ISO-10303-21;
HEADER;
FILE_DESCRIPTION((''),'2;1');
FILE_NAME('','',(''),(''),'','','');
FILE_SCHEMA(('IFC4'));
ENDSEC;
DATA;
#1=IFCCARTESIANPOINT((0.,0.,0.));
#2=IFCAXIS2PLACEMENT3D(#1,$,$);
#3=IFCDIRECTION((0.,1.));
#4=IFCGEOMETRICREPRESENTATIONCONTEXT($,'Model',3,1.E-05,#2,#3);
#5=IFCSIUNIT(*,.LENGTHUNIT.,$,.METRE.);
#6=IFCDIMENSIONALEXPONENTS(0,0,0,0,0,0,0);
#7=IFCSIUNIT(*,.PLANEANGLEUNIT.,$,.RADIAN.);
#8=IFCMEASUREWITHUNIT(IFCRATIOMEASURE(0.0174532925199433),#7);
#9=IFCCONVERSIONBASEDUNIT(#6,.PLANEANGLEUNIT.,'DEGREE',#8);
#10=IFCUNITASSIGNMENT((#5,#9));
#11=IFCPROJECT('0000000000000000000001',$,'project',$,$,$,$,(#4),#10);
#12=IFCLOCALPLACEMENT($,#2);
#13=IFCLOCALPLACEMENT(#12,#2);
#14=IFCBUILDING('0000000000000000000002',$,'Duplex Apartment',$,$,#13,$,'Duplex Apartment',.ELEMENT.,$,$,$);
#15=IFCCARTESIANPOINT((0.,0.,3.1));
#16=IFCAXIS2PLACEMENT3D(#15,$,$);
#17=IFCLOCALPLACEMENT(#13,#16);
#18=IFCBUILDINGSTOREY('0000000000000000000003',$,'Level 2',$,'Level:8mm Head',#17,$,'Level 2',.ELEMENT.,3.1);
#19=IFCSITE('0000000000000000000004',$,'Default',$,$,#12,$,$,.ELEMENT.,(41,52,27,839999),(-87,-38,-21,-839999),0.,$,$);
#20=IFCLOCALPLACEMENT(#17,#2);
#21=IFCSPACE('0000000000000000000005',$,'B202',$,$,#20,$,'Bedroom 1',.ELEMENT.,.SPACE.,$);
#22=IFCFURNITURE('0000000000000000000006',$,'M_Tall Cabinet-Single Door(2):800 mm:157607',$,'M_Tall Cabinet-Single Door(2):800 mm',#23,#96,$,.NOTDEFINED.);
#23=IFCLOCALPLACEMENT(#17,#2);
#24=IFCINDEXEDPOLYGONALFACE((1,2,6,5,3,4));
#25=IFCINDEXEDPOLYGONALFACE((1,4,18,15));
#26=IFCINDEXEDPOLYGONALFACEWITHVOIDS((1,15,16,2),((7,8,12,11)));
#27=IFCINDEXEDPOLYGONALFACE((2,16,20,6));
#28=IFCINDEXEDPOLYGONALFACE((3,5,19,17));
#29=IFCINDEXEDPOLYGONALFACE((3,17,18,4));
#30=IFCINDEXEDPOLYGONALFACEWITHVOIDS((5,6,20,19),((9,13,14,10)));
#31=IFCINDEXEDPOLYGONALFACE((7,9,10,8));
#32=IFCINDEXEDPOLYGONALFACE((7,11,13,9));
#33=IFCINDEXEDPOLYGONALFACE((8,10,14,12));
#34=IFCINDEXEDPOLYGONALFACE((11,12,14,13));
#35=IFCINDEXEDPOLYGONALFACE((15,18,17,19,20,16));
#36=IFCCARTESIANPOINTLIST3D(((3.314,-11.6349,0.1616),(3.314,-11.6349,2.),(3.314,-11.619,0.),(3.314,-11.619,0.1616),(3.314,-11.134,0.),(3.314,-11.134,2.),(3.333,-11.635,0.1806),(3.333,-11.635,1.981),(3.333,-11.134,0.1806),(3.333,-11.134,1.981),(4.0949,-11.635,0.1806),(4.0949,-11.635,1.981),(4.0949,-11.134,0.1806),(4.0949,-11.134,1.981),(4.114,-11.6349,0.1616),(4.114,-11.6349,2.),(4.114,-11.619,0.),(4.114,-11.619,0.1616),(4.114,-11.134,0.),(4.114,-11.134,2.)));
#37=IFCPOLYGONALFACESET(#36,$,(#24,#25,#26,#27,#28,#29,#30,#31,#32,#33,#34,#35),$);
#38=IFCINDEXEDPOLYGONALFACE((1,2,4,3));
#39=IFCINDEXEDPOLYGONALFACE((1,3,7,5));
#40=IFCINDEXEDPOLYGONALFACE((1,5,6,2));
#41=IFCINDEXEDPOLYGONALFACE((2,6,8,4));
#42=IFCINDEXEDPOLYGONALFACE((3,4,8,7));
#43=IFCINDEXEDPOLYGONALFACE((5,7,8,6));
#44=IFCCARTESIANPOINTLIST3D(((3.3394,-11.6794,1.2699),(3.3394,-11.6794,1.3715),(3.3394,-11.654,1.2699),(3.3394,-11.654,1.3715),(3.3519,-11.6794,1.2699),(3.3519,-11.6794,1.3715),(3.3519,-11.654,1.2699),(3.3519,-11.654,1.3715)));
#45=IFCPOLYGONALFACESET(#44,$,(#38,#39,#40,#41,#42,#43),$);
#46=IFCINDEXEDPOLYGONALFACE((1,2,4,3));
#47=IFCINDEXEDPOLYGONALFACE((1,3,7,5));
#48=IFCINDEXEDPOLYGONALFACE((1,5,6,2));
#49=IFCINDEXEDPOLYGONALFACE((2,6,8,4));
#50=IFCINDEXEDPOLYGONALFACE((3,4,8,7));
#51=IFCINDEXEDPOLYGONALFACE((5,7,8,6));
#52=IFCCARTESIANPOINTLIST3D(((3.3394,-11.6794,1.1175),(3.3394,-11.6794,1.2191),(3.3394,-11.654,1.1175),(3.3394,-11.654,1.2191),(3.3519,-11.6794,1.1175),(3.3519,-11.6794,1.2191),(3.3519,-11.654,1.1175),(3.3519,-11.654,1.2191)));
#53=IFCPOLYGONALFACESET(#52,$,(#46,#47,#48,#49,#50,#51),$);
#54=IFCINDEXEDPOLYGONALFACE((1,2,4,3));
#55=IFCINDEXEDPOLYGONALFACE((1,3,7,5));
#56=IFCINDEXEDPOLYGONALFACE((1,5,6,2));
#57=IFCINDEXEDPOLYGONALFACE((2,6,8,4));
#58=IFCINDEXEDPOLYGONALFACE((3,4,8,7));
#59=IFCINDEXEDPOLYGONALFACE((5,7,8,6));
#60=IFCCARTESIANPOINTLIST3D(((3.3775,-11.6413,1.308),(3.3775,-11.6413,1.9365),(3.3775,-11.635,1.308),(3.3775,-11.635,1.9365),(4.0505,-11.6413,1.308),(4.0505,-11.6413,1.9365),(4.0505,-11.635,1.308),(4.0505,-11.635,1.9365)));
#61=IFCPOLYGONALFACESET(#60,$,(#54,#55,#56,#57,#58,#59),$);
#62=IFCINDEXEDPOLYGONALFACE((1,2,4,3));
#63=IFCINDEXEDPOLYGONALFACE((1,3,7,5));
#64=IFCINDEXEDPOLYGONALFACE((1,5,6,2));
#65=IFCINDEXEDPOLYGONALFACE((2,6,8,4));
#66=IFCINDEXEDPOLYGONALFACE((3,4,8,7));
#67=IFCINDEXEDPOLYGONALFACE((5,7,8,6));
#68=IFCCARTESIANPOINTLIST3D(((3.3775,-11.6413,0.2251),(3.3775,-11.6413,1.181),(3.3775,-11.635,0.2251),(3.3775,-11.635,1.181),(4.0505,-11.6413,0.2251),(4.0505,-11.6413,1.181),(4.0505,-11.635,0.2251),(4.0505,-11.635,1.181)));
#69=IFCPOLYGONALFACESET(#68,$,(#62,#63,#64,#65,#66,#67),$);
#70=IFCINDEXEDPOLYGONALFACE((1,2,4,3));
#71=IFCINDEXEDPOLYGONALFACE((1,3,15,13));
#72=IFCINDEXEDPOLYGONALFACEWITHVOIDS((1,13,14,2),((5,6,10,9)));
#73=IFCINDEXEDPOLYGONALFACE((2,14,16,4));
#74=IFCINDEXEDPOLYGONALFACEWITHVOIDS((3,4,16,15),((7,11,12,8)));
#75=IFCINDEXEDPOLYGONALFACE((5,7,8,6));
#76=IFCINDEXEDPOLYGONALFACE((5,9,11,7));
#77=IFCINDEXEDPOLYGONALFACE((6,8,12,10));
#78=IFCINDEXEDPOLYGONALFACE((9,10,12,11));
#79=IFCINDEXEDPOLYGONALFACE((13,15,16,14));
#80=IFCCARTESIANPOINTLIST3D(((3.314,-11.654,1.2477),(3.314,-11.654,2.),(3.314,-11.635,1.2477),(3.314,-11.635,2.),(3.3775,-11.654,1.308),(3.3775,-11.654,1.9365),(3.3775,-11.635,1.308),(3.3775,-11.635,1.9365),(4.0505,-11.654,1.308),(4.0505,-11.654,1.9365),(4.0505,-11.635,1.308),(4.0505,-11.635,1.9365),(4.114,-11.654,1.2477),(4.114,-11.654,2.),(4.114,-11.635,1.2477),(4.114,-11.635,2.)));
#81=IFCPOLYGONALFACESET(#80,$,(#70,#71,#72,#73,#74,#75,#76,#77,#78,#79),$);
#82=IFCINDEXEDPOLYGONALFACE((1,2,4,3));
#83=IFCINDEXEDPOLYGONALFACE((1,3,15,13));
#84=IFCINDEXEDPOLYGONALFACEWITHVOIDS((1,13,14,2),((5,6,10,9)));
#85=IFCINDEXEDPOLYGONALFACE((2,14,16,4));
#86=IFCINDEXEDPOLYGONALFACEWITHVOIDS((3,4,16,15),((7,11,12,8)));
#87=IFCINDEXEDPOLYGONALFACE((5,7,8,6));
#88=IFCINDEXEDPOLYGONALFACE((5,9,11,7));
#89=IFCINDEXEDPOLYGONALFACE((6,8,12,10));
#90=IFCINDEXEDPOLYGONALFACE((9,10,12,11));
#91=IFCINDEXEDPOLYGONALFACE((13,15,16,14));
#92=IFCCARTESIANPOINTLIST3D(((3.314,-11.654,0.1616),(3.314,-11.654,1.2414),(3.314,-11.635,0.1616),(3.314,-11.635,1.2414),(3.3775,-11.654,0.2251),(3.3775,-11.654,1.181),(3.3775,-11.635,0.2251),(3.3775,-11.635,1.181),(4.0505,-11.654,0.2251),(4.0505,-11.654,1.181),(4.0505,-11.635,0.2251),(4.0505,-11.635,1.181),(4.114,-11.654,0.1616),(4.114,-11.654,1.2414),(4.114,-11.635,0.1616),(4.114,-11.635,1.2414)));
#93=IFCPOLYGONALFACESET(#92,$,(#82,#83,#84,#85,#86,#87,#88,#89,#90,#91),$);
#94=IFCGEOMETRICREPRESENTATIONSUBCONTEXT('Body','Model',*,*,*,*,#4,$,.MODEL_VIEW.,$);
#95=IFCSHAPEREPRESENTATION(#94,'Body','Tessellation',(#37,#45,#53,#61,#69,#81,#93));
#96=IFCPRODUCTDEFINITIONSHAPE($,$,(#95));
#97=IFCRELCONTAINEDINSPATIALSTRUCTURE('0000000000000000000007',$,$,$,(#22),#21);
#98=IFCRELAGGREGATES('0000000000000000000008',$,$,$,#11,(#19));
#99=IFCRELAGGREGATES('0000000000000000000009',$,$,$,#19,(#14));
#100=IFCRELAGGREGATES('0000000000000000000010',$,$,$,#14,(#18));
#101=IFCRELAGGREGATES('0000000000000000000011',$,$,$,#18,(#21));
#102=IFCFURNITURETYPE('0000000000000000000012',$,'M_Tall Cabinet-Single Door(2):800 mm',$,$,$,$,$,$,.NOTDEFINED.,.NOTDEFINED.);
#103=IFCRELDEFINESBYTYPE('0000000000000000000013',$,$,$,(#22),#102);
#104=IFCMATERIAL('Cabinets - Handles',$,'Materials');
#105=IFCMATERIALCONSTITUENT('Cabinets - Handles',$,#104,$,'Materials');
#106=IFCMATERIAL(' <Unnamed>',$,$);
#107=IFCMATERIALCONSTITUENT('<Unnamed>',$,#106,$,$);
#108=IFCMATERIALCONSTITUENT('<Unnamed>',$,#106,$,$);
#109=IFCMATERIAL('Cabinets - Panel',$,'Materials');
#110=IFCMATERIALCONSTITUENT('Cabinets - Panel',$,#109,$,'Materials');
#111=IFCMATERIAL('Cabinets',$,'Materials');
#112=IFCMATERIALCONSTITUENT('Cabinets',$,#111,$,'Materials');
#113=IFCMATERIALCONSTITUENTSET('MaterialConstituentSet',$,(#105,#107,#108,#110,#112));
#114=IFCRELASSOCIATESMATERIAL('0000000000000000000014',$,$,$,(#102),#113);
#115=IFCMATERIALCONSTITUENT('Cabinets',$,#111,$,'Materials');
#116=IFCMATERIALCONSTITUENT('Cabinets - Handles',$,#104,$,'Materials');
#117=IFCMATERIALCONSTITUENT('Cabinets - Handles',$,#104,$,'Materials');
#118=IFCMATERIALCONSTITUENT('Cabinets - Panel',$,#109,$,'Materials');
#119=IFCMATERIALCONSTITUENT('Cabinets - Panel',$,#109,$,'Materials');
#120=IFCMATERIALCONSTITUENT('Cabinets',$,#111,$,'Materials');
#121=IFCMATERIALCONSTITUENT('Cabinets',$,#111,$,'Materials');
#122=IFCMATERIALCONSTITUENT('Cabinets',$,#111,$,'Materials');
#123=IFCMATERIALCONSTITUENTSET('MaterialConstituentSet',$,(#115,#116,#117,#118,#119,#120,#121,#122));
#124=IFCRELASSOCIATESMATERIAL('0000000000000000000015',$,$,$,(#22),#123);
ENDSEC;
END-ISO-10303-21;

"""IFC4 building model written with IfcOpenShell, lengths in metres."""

from ifc_helpers import new_model, entity, si_unit, converted_unit, direction, frame, origin, place, context, subcontext, project, spatial, indexed_curve, outline, extrude, source, transform, mapped, material, constituent, constituent_set, type_object, type_shapes, element, save


model = new_model("IFC4")

# Units and contexts
model_context = context("Model", 3, precision=1e-05, world=origin(), true_north=direction((0.0, 1.0)))
body_context = subcontext(model_context, "Body", "Model", "MODEL_VIEW")
ifc_project = project(units=[si_unit("LENGTHUNIT", "METRE"), converted_unit("PLANEANGLEUNIT", "DEGREE", entity("IfcRatioMeasure", 0.0174532925199433), si_unit("PLANEANGLEUNIT", "RADIAN"), dimensions=[0, 0, 0, 0, 0, 0, 0])], contexts=[model_context])

# Site, building, storey
site_placement = place(None, origin())
site = spatial("IfcSite", under=ifc_project, at=site_placement, Name="Default", CompositionType="ELEMENT", RefLatitude=(41, 52, 27, 839999), RefLongitude=(-87, -38, -21, -839999), RefElevation=0.0)
building_placement = place(site_placement, origin())
building = spatial("IfcBuilding", under=site, at=building_placement, Name="Duplex Apartment", LongName="Duplex Apartment", CompositionType="ELEMENT")
storey_placement = place(building_placement, frame((0.0, 0.0, 3.1)))
storey = spatial("IfcBuildingStorey", under=building, at=storey_placement, Name="Level 2", ObjectType="Level:8mm Head", LongName="Level 2", CompositionType="ELEMENT", Elevation=3.1)

# Shared definitions
space_1_placement = place(storey_placement, origin())
space_1 = spatial("IfcSpace", under=storey, at=space_1_placement, Name="B202", LongName="Bedroom 1", CompositionType="ELEMENT", PredefinedType="SPACE")

# Furniture, opening
ifc_material_1 = material(Name="Cabinets", Category="Materials")
ifc_material_2 = material(Name="Cabinets - Handles", Category="Materials")
ifc_material_3 = material(Name="Cabinets - Panel", Category="Materials")
ifc_material_4 = material(Name=" <Unnamed>")
ifc_constituent_1 = constituent(ifc_material_1, Name="Cabinets", Category="Materials")
ifc_constituent_2 = constituent(ifc_material_2, Name="Cabinets - Handles", Category="Materials")
ifc_constituent_3 = constituent(ifc_material_2, Name="Cabinets - Handles", Category="Materials")
ifc_constituent_4 = constituent(ifc_material_3, Name="Cabinets - Panel", Category="Materials")
ifc_constituent_5 = constituent(ifc_material_3, Name="Cabinets - Panel", Category="Materials")
ifc_constituent_6 = constituent(ifc_material_1, Name="Cabinets", Category="Materials")
ifc_constituent_7 = constituent(ifc_material_1, Name="Cabinets", Category="Materials")
ifc_constituent_8 = constituent(ifc_material_1, Name="Cabinets", Category="Materials")
ifc_constituent_set_1 = constituent_set(constituents=[ifc_constituent_1, ifc_constituent_2, ifc_constituent_3, ifc_constituent_4, ifc_constituent_5, ifc_constituent_6, ifc_constituent_7, ifc_constituent_8], Name="MaterialConstituentSet")
ifc_constituent_9 = constituent(ifc_material_2, Name="Cabinets - Handles", Category="Materials")
ifc_constituent_10 = constituent(ifc_material_4, Name="<Unnamed>")
ifc_constituent_11 = constituent(ifc_material_4, Name="<Unnamed>")
ifc_constituent_12 = constituent(ifc_material_3, Name="Cabinets - Panel", Category="Materials")
ifc_constituent_13 = constituent(ifc_material_1, Name="Cabinets", Category="Materials")
ifc_constituent_set_2 = constituent_set(constituents=[ifc_constituent_9, ifc_constituent_10, ifc_constituent_11, ifc_constituent_12, ifc_constituent_13], Name="MaterialConstituentSet")
furniture_type_1 = type_object("IfcFurnitureType", Name="M_Tall Cabinet-Single Door(2):800 mm", AssemblyPlace="NOTDEFINED", PredefinedType="NOTDEFINED", material=ifc_constituent_set_2)
shared_shape_1 = source(origin(), body_context, "Body", "SweptSolid", [
    extrude(outline(indexed_curve([(-0.5589, -0.1723), (1.2795, -0.1723), (1.2795, 0.3286), (-0.7205, 0.3286), (-0.7205, -0.1563), (-0.5589, -0.1563), (-0.5589, -0.1723)], self_intersect=False)), frame((-0.3813, 0.3286, 0.7205), z_axis=(1.0, 0.0, 0.0), x_axis=(0.0, 0.0, 1.0)), (0.0, 0.0, 1.0), 0.8),
    extrude(outline(indexed_curve([(-0.0063, -0.0127), (0.0063, -0.0127), (0.0063, 0.0127), (-0.0063, 0.0127), (-0.0063, -0.0127)], self_intersect=False)), frame((0.3871, 0.5327, 1.2699), z_axis=(0.0, 0.0, 1.0), x_axis=(-1.0, 0.0, 0.0)), (0.0, 0.0, 1.0), 0.1016),
    extrude(outline(indexed_curve([(-0.0063, -0.0127), (0.0063, -0.0127), (0.0063, 0.0127), (-0.0063, 0.0127), (-0.0063, -0.0127)], self_intersect=False)), frame((0.3871, 0.5327, 1.1175), z_axis=(0.0, 0.0, 1.0), x_axis=(-1.0, 0.0, 0.0)), (0.0, 0.0, 1.0), 0.1016),
    extrude(outline(indexed_curve([(-0.3365, -0.0032), (0.3365, -0.0032), (0.3365, 0.0032), (-0.3365, 0.0032), (-0.3365, -0.0032)], self_intersect=False)), frame((0.0187, 0.5041, 1.308), z_axis=(0.0, 0.0, 1.0), x_axis=(-1.0, 0.0, 0.0)), (0.0, 0.0, 1.0), 0.6285),
    extrude(outline(indexed_curve([(-0.3365, -0.0032), (0.3365, -0.0032), (0.3365, 0.0032), (-0.3365, 0.0032), (-0.3365, -0.0032)], self_intersect=False)), frame((0.0187, 0.5041, 0.2251), z_axis=(0.0, 0.0, 1.0), x_axis=(-1.0, 0.0, 0.0)), (0.0, 0.0, 1.0), 0.956),
    extrude(outline(indexed_curve([(-0.3761, -0.4), (0.3761, -0.4), (0.3761, 0.4), (-0.3761, 0.4), (-0.3761, -0.4)], self_intersect=False), holes=[indexed_curve([(-0.3126, -0.3365), (-0.3126, 0.3365), (0.3158, 0.3365), (0.3158, -0.3365), (-0.3126, -0.3365)], self_intersect=False)]), frame((0.0187, 0.501, 1.6239), z_axis=(0.0, 1.0, 0.0), x_axis=(0.0, 0.0, -1.0)), (0.0, 0.0, 1.0), 0.0191),
    extrude(outline(indexed_curve([(-0.4, -0.5399), (0.4, -0.5399), (0.4, 0.5399), (-0.4, 0.5399), (-0.4, -0.5399)], self_intersect=False), holes=[indexed_curve([(-0.3365, 0.4796), (0.3365, 0.4796), (0.3365, -0.4764), (-0.3365, -0.4764), (-0.3365, 0.4796)], self_intersect=False)]), frame((0.0187, 0.501, 0.7015), z_axis=(0.0, 1.0, 0.0), x_axis=(-1.0, 0.0, 0.0)), (0.0, 0.0, 1.0), 0.0191),
    extrude(outline(indexed_curve([(-0.381, -0.0095), (0.381, -0.0095), (0.381, 0.0095), (-0.381, 0.0095), (-0.381, -0.0095)], self_intersect=False)), frame((0.0187, 0.0095, 0.1806), z_axis=(0.0, 0.0, 1.0), x_axis=(-1.0, 0.0, 0.0)), (0.0, 0.0, 1.0), 1.8003),
])
type_shapes(furniture_type_1, [shared_shape_1])
furniture_1_placement = place(space_1_placement, frame((3.7327, -11.134, 0.0), z_axis=(0.0, 0.0, 1.0), x_axis=(-1.0, 0.0, 0.0)))
furniture_1 = element("IfcFurniture", 1, at=furniture_1_placement, inside=space_1, type_object=furniture_type_1, material=ifc_constituent_set_1, Name="M_Tall Cabinet-Single Door(2):800 mm:157607", ObjectType="M_Tall Cabinet-Single Door(2):800 mm", PredefinedType="NOTDEFINED", context=body_context, shape_type="MappedRepresentation", body=[
    mapped(shared_shape_1, transform((0.0, 0.0, 0.0), scale=1.0)),
])
opening_1_placement = place(storey_placement, frame((3.7327, -11.134, 3.1)))
element("IfcOpeningElement", 2, at=opening_1_placement, cuts=furniture_1, ObjectType="Opening", PredefinedType="OPENING", context=body_context, shape_type="SweptSolid", body=[
    extrude(outline(indexed_curve([(-0.9002, -0.381), (0.9002, -0.381), (0.9002, 0.381), (-0.9002, 0.381), (-0.9002, -0.381)], self_intersect=False)), frame((-0.0187, 0.0, -2.0192), z_axis=(0.0, -1.0, 0.0), x_axis=(0.0, 0.0, -1.0)), (0.0, 0.0, 1.0), 0.501),
])

save(model, "model.ifc")
